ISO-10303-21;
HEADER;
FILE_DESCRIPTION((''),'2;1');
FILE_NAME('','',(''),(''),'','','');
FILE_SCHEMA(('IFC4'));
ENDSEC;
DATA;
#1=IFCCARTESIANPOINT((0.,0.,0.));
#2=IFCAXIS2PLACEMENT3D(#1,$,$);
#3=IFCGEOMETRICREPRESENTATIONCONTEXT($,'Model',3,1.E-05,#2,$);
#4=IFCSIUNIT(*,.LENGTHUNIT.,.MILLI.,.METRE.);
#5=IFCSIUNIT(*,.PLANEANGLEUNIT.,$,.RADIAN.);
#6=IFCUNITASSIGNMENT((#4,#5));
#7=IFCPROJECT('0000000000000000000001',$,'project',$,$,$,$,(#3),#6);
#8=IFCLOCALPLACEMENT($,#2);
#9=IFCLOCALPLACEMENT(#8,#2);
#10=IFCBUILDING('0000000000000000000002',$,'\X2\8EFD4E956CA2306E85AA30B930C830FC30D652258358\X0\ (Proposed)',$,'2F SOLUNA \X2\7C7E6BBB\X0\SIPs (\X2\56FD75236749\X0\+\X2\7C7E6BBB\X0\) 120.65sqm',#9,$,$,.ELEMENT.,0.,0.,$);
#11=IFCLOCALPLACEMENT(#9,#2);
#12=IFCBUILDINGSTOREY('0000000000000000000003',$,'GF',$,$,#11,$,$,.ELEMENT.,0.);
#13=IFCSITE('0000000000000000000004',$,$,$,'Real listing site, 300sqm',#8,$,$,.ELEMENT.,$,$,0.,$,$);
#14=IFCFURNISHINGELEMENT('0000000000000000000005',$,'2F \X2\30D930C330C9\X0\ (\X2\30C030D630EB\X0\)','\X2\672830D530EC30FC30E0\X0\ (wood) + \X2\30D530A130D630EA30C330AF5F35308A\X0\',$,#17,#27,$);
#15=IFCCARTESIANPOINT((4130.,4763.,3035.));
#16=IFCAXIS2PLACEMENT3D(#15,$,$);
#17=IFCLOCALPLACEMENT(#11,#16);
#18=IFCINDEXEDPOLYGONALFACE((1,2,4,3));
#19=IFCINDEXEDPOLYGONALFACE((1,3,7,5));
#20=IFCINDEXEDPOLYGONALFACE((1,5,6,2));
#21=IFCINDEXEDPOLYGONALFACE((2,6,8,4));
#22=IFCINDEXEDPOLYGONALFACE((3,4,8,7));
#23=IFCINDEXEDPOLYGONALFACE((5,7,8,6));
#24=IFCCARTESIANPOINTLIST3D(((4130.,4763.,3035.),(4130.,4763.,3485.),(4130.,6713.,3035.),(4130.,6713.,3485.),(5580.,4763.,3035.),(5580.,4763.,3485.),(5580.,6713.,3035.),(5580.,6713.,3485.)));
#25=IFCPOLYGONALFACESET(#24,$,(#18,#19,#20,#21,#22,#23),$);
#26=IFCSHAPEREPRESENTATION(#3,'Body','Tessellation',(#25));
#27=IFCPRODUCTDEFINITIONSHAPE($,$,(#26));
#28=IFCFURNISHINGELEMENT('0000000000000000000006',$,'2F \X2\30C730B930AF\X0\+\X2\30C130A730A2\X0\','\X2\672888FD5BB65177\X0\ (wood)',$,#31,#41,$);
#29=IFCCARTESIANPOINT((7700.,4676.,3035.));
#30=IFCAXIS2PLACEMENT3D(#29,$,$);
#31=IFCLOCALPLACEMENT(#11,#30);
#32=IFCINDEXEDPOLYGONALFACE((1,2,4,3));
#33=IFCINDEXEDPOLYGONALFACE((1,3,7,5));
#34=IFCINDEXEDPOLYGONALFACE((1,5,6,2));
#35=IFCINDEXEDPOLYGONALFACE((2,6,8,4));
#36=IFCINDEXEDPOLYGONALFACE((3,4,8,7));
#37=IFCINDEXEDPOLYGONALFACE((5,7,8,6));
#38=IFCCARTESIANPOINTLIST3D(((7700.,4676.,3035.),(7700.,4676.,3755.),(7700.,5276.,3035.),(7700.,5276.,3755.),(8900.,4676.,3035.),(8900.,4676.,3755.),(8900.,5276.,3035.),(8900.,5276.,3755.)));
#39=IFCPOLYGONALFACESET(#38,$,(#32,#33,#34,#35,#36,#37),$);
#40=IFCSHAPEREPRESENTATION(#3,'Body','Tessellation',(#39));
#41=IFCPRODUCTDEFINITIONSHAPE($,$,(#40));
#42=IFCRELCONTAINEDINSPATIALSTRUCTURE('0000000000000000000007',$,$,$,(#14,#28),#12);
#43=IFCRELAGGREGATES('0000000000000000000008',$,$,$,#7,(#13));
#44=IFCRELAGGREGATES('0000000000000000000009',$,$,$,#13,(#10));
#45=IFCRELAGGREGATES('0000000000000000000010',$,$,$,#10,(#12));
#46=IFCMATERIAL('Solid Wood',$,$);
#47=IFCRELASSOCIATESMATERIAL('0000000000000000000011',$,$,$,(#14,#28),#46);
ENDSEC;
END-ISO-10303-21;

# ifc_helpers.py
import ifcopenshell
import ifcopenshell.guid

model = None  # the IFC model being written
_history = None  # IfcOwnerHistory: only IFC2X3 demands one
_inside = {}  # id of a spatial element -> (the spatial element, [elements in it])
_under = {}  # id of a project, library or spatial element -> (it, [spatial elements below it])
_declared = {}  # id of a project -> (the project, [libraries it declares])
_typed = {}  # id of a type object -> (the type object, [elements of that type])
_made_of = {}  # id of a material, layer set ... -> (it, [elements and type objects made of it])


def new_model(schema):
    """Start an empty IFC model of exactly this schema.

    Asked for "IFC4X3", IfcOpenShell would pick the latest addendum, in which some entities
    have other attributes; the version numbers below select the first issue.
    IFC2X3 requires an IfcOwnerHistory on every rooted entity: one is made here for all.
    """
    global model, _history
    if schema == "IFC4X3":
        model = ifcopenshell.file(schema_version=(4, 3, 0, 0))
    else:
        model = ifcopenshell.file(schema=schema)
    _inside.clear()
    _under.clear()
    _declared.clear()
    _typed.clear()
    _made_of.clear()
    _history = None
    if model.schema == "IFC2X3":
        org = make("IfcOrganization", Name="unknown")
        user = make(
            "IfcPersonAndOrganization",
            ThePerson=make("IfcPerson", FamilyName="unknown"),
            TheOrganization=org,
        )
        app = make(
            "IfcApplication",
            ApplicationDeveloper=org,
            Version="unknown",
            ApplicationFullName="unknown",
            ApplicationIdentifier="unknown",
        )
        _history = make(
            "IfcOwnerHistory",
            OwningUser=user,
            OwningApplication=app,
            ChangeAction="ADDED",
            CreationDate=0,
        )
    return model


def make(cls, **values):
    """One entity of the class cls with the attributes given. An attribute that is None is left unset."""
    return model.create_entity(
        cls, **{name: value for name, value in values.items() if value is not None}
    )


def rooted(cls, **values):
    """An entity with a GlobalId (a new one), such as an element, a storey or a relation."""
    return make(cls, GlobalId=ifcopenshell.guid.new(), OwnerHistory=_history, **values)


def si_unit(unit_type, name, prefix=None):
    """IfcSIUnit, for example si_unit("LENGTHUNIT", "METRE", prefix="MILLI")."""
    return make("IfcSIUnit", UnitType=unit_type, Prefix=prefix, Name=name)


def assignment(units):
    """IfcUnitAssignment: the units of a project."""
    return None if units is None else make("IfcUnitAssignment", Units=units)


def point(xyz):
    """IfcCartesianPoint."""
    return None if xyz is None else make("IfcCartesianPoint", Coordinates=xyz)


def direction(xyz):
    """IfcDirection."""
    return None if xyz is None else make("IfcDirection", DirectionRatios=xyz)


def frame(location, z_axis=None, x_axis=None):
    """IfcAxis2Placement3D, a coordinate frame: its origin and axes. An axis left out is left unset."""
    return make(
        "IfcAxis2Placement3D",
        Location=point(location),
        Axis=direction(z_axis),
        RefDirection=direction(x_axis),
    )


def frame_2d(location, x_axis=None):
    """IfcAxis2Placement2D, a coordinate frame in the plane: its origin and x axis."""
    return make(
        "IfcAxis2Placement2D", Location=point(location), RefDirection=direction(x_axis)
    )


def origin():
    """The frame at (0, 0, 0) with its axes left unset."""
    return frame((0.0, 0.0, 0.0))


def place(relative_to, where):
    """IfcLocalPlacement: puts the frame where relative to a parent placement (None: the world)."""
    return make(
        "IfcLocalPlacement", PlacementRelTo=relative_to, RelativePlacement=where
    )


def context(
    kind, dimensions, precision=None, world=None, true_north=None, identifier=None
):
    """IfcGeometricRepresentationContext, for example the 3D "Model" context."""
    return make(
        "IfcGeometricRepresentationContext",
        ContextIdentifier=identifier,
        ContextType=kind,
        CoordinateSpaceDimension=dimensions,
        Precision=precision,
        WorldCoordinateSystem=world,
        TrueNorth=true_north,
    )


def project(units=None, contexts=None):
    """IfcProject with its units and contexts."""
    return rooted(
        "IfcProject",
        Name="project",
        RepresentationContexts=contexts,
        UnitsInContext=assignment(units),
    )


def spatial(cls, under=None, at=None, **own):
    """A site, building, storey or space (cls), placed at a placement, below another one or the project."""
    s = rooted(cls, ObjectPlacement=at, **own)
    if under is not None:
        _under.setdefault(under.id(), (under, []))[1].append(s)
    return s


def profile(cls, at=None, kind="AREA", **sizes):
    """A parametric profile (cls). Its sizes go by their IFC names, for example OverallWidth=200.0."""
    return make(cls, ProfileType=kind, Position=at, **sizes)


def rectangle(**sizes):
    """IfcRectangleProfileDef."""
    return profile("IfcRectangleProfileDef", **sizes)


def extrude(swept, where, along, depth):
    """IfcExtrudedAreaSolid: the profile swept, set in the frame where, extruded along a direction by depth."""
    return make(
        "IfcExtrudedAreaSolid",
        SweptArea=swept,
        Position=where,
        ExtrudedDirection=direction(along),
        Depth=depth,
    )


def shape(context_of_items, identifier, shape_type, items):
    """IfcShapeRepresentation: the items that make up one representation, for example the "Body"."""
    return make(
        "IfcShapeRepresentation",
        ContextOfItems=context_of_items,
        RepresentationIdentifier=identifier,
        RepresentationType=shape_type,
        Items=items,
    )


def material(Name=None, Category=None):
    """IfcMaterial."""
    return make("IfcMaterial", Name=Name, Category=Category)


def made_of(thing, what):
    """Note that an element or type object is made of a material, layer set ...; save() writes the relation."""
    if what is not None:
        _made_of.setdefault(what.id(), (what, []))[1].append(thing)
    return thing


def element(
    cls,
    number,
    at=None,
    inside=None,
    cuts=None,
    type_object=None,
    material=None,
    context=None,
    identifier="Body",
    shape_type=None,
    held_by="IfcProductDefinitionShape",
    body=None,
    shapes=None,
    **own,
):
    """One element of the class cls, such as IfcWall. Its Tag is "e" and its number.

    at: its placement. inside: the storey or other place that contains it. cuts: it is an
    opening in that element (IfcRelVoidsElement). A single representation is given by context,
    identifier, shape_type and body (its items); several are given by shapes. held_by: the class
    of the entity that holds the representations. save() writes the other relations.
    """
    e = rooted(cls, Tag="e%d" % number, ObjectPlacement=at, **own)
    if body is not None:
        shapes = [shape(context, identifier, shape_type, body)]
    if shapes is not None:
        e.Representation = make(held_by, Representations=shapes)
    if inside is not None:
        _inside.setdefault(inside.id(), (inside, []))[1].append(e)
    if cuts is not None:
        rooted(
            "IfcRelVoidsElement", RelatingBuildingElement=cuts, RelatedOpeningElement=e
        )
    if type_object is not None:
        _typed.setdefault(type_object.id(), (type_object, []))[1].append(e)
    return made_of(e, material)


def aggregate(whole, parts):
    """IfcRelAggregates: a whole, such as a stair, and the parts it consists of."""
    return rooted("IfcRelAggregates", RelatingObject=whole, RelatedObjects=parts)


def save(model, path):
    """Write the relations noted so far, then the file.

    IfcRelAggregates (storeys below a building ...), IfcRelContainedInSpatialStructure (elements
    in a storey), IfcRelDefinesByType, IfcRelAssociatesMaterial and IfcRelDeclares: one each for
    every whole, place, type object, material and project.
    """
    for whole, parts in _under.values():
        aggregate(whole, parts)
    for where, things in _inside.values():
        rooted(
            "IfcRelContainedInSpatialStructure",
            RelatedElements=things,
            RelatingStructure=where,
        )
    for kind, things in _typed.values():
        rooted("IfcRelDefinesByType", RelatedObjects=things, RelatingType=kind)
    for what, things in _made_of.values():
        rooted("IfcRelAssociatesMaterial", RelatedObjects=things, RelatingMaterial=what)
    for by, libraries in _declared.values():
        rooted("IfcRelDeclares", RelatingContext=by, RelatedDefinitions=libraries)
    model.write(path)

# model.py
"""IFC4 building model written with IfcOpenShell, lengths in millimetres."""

from ifc_helpers import new_model, si_unit, frame, frame_2d, origin, place, context, project, spatial, rectangle, extrude, material, element, save


model = new_model("IFC4")

# Units and contexts
model_context = context("Model", 3, precision=1e-05, world=origin())
ifc_project = project(units=[si_unit("LENGTHUNIT", "METRE", prefix="MILLI"), si_unit("PLANEANGLEUNIT", "RADIAN")], contexts=[model_context])

# Site, building, storey
site_placement = place(None, origin())
site = spatial("IfcSite", under=ifc_project, at=site_placement, ObjectType="Real listing site, 300sqm", CompositionType="ELEMENT", RefElevation=0.0)
building_placement = place(site_placement, origin())
building = spatial("IfcBuilding", under=site, at=building_placement, Name="軽井沢の薪ストーブ別荘 (Proposed)", ObjectType="2F SOLUNA 籾殻SIPs (国産杉+籾殻) 120.65sqm", CompositionType="ELEMENT", ElevationOfRefHeight=0.0, ElevationOfTerrain=0.0)
storey_placement = place(building_placement, origin())
storey = spatial("IfcBuildingStorey", under=building, at=storey_placement, Name="GF", CompositionType="ELEMENT", Elevation=0.0)

# Shared definitions
ifc_material_1 = material(Name="Solid Wood")

# Furnishing elements
furnishing_1_placement = place(storey_placement, frame((4130.0, 4763.0, 3035.0)))
element("IfcFurnishingElement", 1, at=furnishing_1_placement, inside=storey, material=ifc_material_1, Name="2F ベッド (ダブル)", Description="木フレーム (wood) + ファブリック張り", context=model_context, shape_type="SweptSolid", body=[
    extrude(rectangle(XDim=1450.0, YDim=1950.0, at=frame_2d((725.0, 975.0))), frame((4130.0, 4763.0, 3035.0)), (0.0, 0.0, 1.0), 450.0),
])
furnishing_2_placement = place(storey_placement, frame((7700.0, 4676.0, 3035.0)))
element("IfcFurnishingElement", 2, at=furnishing_2_placement, inside=storey, material=ifc_material_1, Name="2F デスク+チェア", Description="木製家具 (wood)", context=model_context, shape_type="SweptSolid", body=[
    extrude(rectangle(XDim=1200.0, YDim=600.0, at=frame_2d((600.0, 300.0))), frame((7700.0, 4676.0, 3035.0)), (0.0, 0.0, 1.0), 720.0),
])

save(model, "model.ifc")
